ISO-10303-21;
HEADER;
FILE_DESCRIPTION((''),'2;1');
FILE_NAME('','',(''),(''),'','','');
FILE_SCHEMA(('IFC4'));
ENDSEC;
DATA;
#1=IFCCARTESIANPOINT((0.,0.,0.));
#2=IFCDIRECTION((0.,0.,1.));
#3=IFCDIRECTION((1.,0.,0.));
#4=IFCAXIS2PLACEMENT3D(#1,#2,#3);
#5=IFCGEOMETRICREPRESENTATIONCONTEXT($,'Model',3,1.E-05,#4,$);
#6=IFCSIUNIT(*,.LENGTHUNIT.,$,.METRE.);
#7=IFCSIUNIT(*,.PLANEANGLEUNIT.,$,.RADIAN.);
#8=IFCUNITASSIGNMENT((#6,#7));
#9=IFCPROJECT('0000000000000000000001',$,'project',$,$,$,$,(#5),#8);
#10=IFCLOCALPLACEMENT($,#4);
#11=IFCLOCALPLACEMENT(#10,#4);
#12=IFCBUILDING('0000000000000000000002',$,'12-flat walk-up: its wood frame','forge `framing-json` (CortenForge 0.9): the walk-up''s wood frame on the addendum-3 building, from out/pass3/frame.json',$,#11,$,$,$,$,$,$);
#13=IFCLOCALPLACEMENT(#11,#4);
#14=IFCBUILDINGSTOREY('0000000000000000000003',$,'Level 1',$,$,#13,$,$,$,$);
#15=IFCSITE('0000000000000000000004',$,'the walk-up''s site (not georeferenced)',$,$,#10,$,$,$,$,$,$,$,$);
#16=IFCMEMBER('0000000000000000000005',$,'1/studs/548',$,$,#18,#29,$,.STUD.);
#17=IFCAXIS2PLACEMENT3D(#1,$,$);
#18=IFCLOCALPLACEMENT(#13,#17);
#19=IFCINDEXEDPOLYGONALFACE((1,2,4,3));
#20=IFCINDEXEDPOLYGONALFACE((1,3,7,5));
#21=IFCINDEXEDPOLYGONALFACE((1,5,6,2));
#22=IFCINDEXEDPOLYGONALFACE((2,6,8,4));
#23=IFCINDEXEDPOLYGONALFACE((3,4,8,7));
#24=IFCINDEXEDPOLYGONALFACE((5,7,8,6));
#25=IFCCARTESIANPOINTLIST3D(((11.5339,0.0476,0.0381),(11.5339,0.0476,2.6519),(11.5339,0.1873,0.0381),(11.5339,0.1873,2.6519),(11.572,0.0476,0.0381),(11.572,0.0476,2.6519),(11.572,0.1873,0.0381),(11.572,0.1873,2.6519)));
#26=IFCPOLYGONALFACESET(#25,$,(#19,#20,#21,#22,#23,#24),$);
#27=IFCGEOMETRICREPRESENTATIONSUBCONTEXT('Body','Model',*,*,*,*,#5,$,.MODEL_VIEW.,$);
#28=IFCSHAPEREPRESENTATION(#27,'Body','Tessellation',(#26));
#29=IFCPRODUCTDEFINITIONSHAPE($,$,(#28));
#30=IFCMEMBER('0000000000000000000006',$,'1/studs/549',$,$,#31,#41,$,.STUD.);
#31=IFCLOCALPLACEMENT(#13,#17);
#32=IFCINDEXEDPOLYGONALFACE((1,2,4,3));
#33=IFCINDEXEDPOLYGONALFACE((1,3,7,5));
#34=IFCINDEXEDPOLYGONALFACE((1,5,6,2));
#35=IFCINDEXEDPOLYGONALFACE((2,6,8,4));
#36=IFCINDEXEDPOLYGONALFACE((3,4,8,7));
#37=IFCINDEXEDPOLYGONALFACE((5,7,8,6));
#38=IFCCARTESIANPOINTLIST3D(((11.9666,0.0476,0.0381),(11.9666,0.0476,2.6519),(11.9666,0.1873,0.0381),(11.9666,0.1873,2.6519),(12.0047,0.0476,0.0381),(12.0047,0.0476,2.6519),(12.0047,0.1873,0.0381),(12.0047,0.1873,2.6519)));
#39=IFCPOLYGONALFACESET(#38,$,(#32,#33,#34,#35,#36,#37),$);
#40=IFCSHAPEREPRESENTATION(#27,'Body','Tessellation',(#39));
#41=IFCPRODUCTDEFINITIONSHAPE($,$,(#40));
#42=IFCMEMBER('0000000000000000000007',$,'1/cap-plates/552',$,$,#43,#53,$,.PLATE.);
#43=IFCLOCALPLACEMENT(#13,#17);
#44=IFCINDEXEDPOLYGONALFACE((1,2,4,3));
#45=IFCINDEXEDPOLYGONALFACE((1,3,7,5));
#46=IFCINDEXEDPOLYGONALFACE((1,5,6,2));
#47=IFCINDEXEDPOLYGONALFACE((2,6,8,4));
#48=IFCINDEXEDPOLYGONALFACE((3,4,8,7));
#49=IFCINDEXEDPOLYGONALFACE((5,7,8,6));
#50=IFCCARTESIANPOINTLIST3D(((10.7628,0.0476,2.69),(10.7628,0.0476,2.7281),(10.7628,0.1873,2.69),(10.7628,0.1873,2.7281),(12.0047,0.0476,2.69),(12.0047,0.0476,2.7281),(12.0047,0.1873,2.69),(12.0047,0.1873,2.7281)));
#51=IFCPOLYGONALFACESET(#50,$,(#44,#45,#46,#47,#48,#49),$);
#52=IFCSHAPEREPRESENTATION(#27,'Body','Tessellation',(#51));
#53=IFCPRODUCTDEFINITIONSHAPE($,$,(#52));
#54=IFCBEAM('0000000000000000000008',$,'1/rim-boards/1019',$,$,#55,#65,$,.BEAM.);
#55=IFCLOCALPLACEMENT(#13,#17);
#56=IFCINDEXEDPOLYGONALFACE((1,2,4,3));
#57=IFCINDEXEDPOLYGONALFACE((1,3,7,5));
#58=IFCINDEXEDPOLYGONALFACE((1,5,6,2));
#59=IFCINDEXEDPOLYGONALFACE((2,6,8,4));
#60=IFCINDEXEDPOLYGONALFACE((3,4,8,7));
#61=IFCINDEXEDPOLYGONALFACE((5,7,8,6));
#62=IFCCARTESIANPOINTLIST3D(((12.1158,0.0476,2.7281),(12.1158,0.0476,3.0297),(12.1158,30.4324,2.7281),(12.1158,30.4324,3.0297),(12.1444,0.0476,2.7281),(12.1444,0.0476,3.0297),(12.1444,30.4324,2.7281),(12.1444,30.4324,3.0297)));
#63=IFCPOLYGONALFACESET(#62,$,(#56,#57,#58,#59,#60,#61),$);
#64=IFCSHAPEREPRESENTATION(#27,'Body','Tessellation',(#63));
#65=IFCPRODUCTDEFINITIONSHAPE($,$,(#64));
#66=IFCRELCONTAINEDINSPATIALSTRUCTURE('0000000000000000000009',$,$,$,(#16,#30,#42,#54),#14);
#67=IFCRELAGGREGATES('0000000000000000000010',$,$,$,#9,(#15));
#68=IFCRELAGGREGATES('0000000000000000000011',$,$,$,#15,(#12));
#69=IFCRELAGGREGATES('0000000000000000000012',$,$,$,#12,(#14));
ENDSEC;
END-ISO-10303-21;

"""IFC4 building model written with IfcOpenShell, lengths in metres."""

from ifc_helpers import new_model, si_unit, frame, frame_2d, origin, origin_with_axes, place, context, subcontext, project, spatial, rectangle, extrude, element, save


model = new_model("IFC4")

# Units and contexts
model_context = context("Model", 3, precision=1e-05, world=origin_with_axes())
body_context = subcontext(model_context, "Body", "Model", "MODEL_VIEW")
ifc_project = project(units=[si_unit("LENGTHUNIT", "METRE"), si_unit("PLANEANGLEUNIT", "RADIAN")], contexts=[model_context])

# Site, building, storey
site_placement = place(None, origin_with_axes())
site = spatial("IfcSite", under=ifc_project, at=site_placement, Name="the walk-up's site (not georeferenced)")
building_placement = place(site_placement, origin_with_axes())
building = spatial("IfcBuilding", under=site, at=building_placement, Name="12-flat walk-up: its wood frame", Description="forge `framing-json` (CortenForge 0.9): the walk-up's wood frame on the addendum-3 building, from out/pass3/frame.json")
storey_placement = place(building_placement, origin_with_axes())
storey = spatial("IfcBuildingStorey", under=building, at=storey_placement, Name="Level 1")

# Members
for number, where, z_axis, x_axis, name in (
    (1, (11.5339, 0.0476, 0.0381), (0.0, 0.0, 1.0), (1.0, 0.0, 0.0), "1/studs/548"),
    (2, (11.9666, 0.0476, 0.0381), (0.0, 0.0, 1.0), (1.0, 0.0, 0.0), "1/studs/549"),
):
    element("IfcMember", number, at=place(storey_placement, frame(where, z_axis=z_axis, x_axis=x_axis)), inside=storey, Name=name, PredefinedType="STUD", context=body_context, shape_type="SweptSolid", body=[
        extrude(rectangle(XDim=0.0381, YDim=0.1397, at=frame_2d((0.0191, 0.0698))), origin(), (0.0, 0.0, 1.0), 2.6138),
    ])
member_1_placement = place(storey_placement, frame((10.7628, 0.0476, 2.69), z_axis=(0.0, 0.0, 1.0), x_axis=(1.0, 0.0, 0.0)))
element("IfcMember", 3, at=member_1_placement, inside=storey, Name="1/cap-plates/552", PredefinedType="PLATE", context=body_context, shape_type="SweptSolid", body=[
    extrude(rectangle(XDim=1.2419, YDim=0.1397, at=frame_2d((0.6209, 0.0698))), origin(), (0.0, 0.0, 1.0), 0.0381),
])

# Beam
beam_placement = place(storey_placement, frame((12.1158, 0.0476, 2.7281), z_axis=(0.0, 0.0, 1.0), x_axis=(1.0, 0.0, 0.0)))
element("IfcBeam", 4, at=beam_placement, inside=storey, Name="1/rim-boards/1019", PredefinedType="BEAM", context=body_context, shape_type="SweptSolid", body=[
    extrude(rectangle(XDim=0.0286, YDim=30.3848, at=frame_2d((0.0143, 15.1924))), origin(), (0.0, 0.0, 1.0), 0.3016),
])

save(model, "model.ifc")
